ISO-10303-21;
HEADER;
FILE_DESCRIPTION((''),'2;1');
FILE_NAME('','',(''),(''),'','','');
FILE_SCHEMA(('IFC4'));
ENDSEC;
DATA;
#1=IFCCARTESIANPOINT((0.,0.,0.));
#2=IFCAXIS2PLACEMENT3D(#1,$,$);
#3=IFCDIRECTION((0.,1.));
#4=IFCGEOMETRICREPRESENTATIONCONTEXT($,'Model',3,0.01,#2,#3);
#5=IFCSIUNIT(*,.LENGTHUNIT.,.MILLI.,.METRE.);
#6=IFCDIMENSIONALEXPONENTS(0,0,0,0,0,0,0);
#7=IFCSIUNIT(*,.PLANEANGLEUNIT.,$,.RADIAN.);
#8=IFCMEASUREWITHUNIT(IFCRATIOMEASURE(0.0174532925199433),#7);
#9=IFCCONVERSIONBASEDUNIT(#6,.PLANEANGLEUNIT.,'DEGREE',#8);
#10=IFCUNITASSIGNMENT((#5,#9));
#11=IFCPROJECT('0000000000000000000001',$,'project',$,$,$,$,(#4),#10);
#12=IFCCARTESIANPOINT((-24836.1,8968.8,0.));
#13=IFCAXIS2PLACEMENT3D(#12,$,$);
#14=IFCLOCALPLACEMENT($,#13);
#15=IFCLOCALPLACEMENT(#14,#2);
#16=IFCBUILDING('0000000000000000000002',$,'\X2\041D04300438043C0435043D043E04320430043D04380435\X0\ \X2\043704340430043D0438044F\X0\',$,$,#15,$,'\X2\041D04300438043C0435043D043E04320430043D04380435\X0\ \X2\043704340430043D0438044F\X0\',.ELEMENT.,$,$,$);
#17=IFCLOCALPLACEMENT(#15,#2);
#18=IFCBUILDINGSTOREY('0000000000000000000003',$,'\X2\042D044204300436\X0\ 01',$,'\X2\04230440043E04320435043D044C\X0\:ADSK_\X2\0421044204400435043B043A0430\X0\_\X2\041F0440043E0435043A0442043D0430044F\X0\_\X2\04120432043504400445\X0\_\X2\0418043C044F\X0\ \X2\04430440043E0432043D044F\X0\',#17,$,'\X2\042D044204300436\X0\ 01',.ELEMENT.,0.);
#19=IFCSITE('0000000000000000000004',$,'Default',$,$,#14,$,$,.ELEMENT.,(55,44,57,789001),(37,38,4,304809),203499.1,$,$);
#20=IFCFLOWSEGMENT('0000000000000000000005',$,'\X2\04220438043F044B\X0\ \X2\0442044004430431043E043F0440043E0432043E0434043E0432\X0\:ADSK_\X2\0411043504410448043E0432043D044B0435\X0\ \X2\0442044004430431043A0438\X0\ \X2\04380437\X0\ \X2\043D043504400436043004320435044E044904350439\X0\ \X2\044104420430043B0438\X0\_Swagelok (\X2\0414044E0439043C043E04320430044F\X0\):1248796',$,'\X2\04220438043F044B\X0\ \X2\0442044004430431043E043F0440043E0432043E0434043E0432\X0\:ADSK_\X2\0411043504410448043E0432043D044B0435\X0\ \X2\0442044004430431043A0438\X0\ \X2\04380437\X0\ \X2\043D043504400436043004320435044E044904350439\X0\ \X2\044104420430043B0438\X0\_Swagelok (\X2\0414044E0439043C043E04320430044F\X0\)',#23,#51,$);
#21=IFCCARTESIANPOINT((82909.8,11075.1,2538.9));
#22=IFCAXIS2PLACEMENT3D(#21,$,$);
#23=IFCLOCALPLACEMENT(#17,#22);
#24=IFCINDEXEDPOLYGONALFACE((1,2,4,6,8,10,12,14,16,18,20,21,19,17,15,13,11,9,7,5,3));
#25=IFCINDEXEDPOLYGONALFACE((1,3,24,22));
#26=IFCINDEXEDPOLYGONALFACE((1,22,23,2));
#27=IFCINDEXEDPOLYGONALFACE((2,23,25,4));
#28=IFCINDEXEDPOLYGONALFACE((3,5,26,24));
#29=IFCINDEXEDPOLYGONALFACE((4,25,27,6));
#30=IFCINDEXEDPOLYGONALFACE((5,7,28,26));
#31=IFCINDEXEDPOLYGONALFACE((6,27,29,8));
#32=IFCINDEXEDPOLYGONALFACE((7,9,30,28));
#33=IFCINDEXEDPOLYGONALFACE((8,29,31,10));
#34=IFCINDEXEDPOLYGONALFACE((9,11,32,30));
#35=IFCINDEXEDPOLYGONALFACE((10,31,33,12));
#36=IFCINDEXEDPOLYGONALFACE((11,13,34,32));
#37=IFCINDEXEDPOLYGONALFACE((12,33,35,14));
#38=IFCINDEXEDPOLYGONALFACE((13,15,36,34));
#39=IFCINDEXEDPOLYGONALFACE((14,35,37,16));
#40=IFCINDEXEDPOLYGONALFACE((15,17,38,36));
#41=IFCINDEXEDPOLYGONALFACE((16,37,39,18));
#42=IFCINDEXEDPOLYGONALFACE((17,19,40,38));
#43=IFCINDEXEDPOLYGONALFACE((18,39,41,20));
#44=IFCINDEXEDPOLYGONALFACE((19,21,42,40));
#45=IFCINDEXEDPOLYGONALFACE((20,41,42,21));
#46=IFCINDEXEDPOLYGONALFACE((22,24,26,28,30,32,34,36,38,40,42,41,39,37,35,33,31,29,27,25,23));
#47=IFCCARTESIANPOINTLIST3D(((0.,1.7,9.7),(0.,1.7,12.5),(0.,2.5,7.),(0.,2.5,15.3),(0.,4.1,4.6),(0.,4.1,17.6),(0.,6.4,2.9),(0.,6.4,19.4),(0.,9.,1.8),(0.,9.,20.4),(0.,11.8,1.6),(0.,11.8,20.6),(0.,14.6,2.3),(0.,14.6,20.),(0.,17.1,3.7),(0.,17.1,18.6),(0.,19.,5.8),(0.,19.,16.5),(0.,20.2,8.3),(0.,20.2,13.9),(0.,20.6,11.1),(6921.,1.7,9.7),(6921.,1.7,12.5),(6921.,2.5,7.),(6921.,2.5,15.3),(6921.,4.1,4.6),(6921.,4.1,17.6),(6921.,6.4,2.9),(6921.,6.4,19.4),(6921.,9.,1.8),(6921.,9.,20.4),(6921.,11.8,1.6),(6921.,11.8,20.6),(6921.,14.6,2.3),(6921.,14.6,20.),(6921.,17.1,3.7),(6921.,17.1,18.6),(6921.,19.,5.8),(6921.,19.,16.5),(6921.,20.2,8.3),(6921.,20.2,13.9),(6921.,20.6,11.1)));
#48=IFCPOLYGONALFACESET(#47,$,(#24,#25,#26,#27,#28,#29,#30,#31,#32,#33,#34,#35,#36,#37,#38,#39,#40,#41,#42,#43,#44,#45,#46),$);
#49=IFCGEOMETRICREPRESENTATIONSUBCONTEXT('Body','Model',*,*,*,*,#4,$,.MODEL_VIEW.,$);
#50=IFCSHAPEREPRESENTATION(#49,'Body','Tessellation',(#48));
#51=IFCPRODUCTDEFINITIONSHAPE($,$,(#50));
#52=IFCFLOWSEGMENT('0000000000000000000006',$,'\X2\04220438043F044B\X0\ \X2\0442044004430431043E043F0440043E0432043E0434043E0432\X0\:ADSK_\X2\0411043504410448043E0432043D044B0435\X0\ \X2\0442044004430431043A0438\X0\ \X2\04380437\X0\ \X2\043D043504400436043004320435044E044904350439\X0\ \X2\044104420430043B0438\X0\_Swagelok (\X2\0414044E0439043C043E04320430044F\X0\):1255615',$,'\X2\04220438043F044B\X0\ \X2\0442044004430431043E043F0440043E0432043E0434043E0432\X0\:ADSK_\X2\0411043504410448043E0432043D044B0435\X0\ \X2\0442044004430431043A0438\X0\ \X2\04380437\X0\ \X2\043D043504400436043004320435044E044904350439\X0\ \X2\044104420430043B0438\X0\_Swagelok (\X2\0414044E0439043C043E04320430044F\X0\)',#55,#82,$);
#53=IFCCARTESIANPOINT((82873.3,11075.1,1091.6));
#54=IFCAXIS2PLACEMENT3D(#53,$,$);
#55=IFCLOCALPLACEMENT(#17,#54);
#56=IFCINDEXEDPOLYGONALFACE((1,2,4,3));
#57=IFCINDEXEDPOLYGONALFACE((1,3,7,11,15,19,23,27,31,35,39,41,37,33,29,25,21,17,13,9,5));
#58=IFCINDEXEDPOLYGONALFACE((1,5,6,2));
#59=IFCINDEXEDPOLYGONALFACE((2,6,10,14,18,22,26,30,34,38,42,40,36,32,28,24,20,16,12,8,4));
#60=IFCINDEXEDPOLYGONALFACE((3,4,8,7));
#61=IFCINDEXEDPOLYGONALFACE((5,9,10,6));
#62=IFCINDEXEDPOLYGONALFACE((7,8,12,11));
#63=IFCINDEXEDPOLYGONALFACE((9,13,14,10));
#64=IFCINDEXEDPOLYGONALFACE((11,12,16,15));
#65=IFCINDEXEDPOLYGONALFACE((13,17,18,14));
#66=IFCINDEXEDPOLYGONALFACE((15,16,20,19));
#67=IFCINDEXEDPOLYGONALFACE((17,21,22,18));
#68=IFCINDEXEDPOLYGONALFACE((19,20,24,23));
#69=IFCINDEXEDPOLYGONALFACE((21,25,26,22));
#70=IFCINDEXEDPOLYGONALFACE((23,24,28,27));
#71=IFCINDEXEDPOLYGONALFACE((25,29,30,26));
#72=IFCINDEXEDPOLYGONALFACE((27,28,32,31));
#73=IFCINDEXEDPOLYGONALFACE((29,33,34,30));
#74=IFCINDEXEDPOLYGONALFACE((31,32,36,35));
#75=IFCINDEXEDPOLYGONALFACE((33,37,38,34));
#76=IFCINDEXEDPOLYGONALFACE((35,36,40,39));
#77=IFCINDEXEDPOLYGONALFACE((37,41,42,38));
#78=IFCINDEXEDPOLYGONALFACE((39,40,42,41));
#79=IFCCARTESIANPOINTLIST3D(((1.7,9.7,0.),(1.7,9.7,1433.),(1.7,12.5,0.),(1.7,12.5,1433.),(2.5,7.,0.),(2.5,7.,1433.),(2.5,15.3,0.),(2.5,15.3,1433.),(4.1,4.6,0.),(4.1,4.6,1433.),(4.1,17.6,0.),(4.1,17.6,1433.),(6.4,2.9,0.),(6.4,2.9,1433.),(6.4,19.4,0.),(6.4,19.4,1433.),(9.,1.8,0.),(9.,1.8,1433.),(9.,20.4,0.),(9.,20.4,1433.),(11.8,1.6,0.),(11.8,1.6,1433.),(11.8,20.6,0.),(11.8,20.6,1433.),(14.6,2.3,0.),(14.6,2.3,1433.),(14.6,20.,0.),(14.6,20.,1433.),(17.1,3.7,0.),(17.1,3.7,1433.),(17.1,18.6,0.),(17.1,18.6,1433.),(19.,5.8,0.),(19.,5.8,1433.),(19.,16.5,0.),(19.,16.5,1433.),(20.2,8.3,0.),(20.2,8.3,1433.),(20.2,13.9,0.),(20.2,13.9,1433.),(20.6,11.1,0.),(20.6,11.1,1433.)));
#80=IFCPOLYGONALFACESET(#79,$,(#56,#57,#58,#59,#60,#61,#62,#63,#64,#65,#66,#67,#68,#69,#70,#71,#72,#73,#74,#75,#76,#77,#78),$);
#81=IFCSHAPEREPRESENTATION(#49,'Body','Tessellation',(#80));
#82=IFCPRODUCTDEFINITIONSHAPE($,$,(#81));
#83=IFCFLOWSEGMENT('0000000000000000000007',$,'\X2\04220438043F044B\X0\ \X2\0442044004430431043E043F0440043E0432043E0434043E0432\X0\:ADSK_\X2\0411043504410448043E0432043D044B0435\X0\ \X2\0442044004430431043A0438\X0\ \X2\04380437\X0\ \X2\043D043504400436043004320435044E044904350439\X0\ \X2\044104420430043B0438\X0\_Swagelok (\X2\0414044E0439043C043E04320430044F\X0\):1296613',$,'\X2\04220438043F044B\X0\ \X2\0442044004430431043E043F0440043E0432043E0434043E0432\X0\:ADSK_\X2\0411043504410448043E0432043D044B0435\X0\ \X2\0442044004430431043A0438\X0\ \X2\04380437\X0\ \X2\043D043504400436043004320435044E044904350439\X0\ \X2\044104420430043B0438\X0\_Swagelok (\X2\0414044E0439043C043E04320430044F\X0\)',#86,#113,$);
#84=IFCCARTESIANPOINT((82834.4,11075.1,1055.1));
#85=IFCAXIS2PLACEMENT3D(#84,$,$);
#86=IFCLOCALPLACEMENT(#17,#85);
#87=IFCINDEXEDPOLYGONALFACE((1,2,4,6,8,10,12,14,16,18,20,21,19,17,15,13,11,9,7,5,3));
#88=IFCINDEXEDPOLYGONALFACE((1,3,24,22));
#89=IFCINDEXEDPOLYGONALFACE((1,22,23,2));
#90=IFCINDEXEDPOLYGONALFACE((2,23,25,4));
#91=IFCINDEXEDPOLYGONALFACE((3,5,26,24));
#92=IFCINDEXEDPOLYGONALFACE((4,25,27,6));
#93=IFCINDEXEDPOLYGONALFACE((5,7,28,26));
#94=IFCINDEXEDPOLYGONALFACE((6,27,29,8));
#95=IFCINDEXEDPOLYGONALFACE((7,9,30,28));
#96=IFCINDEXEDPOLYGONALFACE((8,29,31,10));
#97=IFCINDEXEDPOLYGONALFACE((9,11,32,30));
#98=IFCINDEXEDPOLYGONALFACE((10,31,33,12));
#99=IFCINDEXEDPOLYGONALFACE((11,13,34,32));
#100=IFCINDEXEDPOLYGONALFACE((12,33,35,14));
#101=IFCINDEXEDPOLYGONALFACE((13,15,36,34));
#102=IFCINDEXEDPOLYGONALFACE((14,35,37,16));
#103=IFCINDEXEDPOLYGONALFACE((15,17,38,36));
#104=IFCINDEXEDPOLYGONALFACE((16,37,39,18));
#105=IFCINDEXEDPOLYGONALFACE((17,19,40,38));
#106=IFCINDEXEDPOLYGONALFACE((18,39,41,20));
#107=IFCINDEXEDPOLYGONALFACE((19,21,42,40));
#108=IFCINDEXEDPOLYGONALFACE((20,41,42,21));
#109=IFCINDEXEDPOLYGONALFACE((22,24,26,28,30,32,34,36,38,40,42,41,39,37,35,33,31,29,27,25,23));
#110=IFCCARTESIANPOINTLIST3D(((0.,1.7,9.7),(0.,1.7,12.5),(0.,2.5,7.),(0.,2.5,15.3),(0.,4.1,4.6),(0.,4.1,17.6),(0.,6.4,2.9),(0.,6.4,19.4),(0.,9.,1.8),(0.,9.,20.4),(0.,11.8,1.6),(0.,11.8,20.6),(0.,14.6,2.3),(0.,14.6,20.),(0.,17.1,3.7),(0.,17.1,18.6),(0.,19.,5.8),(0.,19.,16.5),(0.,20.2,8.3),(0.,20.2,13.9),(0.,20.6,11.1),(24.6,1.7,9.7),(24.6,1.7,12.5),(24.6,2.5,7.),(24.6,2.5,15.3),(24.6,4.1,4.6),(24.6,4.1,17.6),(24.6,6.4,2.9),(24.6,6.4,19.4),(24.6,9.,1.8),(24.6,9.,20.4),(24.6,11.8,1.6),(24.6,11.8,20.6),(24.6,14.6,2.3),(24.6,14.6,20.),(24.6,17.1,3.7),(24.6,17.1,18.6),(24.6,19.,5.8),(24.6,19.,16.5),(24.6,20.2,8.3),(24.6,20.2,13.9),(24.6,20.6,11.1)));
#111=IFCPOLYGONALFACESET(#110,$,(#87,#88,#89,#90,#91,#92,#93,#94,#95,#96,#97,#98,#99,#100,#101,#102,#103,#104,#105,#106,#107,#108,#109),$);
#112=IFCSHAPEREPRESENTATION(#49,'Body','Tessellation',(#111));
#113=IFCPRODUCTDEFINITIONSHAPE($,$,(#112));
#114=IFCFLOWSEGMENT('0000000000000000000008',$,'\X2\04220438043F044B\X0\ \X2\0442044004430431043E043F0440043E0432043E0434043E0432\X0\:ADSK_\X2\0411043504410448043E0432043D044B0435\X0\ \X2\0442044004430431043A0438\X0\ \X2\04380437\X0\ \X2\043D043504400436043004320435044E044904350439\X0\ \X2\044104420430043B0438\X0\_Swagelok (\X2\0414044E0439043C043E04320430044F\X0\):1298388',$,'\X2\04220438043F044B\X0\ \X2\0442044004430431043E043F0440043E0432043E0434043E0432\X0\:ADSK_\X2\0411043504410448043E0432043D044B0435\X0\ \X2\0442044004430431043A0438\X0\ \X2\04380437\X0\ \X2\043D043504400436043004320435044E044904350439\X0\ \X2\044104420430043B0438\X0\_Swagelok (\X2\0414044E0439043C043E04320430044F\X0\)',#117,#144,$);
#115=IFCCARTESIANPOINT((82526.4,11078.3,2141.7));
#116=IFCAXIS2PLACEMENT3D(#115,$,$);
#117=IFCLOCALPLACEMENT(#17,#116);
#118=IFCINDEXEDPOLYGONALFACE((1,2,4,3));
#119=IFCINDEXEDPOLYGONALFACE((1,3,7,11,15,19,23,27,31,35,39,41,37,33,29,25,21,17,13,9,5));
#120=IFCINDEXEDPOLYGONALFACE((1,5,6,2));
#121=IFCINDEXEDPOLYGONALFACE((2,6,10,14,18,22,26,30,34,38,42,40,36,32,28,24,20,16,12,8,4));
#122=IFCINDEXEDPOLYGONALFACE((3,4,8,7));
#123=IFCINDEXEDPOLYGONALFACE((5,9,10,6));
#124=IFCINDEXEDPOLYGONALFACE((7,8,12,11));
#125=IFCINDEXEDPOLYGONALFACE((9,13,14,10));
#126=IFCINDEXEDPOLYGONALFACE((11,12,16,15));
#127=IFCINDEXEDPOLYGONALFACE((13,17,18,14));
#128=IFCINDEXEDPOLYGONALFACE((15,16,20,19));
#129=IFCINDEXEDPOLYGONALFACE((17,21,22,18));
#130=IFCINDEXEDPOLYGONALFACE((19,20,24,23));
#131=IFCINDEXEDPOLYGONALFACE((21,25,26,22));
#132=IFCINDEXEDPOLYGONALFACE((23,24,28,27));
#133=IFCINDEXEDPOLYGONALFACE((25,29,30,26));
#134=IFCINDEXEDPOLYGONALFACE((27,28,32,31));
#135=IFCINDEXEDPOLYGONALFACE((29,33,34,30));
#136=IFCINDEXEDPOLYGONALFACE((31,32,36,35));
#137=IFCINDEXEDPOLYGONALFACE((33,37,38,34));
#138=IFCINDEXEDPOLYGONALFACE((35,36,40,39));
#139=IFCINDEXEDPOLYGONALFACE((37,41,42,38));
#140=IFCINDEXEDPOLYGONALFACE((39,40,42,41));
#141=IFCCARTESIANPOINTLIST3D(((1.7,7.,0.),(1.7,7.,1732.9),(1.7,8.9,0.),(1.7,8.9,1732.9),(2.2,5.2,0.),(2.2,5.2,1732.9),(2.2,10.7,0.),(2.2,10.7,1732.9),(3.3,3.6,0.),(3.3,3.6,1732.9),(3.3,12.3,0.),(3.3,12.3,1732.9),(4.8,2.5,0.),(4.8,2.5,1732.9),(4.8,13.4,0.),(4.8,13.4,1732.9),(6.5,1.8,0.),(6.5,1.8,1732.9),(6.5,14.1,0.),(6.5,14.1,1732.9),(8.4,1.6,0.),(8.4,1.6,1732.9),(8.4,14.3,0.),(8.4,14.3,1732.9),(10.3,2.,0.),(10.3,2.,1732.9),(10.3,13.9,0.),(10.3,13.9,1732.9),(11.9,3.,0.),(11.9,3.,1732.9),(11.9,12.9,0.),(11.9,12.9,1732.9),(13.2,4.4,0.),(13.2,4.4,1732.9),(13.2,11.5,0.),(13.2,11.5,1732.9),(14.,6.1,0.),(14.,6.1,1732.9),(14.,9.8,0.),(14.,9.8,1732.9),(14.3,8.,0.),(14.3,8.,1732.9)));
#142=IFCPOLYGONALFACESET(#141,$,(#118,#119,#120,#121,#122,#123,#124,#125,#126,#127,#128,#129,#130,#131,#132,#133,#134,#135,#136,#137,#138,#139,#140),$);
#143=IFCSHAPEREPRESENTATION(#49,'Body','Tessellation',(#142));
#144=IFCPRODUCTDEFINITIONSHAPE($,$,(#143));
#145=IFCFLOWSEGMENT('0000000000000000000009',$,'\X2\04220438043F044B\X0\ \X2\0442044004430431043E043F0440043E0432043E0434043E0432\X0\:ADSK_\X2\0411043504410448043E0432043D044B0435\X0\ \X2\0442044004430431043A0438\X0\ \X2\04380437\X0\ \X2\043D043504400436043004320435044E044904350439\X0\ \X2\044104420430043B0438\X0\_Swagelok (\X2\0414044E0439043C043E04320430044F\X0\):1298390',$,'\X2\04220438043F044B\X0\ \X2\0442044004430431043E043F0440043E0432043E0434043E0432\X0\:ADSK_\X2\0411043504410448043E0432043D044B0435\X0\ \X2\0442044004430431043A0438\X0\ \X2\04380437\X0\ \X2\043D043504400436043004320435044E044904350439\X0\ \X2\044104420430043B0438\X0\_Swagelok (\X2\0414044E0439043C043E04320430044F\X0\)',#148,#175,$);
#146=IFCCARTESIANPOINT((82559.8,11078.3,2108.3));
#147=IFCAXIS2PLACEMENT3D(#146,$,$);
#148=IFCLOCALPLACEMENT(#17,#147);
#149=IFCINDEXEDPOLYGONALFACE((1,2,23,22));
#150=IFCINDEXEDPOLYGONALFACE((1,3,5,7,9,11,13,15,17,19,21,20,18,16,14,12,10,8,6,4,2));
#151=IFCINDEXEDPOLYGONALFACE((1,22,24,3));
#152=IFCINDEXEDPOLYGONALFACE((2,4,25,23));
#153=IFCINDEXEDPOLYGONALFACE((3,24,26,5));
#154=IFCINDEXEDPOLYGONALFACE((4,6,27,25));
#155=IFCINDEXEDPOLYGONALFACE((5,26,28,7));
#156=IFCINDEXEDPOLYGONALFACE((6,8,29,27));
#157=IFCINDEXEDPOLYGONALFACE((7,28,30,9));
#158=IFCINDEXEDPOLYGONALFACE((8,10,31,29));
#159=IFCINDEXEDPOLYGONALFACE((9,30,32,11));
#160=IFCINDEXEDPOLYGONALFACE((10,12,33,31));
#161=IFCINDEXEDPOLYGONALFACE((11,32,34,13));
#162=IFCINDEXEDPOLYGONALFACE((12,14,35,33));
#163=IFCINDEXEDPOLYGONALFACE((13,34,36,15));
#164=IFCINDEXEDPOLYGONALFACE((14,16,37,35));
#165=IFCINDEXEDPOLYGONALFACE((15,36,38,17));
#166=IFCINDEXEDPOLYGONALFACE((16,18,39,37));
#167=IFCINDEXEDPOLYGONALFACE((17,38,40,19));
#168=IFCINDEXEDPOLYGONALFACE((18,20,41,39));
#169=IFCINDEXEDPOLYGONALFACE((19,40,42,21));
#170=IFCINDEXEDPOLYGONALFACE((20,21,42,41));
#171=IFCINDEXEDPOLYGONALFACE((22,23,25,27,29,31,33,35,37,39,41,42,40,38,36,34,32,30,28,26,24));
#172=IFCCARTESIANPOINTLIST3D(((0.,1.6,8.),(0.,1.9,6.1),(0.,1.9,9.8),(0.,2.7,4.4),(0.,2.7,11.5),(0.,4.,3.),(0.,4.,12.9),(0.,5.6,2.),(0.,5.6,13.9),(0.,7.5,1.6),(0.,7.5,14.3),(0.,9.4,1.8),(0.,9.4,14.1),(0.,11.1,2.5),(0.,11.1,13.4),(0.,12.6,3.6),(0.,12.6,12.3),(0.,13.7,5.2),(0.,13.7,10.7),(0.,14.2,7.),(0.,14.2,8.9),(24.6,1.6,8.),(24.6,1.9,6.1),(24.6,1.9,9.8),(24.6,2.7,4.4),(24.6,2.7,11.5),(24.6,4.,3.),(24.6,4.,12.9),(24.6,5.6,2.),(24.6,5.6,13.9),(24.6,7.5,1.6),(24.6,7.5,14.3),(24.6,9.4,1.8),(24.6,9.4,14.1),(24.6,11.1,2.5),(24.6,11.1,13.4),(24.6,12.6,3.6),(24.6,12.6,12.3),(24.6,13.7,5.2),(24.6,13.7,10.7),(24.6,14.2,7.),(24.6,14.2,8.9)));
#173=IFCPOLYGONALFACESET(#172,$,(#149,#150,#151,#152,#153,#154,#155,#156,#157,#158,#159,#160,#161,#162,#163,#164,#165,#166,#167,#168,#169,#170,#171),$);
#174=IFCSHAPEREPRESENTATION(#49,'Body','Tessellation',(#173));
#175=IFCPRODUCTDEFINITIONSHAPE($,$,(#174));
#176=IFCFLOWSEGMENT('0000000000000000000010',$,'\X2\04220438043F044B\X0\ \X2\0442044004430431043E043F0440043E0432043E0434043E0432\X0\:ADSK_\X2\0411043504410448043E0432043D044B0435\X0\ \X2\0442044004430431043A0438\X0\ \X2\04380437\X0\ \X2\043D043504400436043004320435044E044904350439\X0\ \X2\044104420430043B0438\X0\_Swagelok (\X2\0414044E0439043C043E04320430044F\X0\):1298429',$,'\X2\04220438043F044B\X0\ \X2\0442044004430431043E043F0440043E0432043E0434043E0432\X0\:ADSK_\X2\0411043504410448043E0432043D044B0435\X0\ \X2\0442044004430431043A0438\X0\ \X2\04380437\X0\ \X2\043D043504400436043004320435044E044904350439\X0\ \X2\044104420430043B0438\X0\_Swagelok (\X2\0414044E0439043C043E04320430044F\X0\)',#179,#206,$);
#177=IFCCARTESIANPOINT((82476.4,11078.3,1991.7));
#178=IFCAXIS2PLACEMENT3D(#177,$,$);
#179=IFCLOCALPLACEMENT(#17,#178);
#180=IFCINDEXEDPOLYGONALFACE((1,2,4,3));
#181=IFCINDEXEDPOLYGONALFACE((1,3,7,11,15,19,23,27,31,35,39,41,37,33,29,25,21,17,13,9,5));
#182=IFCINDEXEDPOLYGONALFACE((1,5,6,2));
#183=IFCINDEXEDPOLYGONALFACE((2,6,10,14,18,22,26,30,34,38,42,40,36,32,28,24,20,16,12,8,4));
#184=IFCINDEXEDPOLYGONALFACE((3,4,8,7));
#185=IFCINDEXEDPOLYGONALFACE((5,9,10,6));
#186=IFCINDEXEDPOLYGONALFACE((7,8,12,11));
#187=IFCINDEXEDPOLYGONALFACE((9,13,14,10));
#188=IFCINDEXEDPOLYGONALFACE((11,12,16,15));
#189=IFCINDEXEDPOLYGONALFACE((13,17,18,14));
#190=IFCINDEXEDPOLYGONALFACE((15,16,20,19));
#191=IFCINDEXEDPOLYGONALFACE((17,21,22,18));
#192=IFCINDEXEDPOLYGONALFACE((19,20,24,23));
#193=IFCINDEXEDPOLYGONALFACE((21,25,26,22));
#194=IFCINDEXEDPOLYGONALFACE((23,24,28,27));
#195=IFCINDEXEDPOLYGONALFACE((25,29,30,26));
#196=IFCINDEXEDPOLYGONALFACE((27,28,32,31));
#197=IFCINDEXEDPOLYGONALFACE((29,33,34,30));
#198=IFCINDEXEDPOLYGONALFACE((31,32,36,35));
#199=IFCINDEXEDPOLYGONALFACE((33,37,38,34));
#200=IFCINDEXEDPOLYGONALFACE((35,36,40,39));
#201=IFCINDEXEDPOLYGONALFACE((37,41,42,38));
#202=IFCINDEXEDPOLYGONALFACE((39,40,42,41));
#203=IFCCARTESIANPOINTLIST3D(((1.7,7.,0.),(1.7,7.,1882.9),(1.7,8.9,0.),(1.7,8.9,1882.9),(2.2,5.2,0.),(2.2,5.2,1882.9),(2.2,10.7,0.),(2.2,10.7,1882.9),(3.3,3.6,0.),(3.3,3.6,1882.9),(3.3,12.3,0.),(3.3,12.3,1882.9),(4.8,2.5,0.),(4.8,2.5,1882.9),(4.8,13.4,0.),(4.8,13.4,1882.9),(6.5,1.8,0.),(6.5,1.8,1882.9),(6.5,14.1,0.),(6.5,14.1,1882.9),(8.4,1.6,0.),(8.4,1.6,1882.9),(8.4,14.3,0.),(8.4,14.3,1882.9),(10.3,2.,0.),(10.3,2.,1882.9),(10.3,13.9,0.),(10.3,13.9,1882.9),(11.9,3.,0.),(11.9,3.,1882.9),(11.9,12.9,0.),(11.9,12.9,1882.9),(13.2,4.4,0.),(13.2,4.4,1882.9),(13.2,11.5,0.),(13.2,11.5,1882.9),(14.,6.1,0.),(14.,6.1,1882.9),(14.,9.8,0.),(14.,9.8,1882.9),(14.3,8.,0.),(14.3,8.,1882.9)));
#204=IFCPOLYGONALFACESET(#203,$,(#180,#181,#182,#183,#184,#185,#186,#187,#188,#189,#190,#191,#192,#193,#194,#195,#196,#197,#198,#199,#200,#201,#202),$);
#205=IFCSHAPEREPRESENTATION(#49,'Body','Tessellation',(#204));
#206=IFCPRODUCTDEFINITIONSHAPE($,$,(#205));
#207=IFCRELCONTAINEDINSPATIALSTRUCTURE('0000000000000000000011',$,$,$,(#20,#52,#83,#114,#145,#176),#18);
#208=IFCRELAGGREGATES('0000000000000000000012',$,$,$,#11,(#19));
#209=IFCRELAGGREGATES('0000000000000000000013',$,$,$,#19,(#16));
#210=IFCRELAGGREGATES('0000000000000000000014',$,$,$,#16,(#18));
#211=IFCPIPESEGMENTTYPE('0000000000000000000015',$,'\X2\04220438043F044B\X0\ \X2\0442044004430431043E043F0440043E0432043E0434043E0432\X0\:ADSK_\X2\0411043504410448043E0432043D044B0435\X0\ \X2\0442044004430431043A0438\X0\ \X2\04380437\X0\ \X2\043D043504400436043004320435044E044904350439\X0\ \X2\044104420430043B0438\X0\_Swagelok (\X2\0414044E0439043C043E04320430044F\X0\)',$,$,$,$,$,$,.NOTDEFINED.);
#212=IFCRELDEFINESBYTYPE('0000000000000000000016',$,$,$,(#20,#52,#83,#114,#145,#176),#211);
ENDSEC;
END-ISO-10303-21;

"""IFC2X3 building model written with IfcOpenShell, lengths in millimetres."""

from ifc_helpers import new_model, entity, si_unit, converted_unit, direction, frame, origin, origin_2d_with_axis, place, context, subcontext, project, spatial, circle, extrude, type_object, element, save


model = new_model("IFC2X3")

# Units and contexts
model_context = context("Model", 3, precision=0.01, world=origin(), true_north=direction((0.0, 1.0)))
body_context = subcontext(model_context, "Body", "Model", "MODEL_VIEW")
ifc_project = project(units=[si_unit("LENGTHUNIT", "METRE", prefix="MILLI"), converted_unit("PLANEANGLEUNIT", "DEGREE", entity("IfcRatioMeasure", 0.0174532925199433), si_unit("PLANEANGLEUNIT", "RADIAN"), dimensions=[0, 0, 0, 0, 0, 0, 0])], contexts=[model_context])

# Site, building, storey
site_placement = place(None, frame((-24836.1, 8968.8, 0.0)))
site = spatial("IfcSite", under=ifc_project, at=site_placement, Name="Default", CompositionType="ELEMENT", RefLatitude=(55, 44, 57, 789001), RefLongitude=(37, 38, 4, 304809), RefElevation=203499.1)
building_placement = place(site_placement, origin())
building = spatial("IfcBuilding", under=site, at=building_placement, Name="Наименование здания", LongName="Наименование здания", CompositionType="ELEMENT")
storey_placement = place(building_placement, origin())
storey = spatial("IfcBuildingStorey", under=building, at=storey_placement, Name="Этаж 01", ObjectType="Уровень:ADSK_Стрелка_Проектная_Вверх_Имя уровня", LongName="Этаж 01", CompositionType="ELEMENT", Elevation=0.0)

# Flow segments
pipe_segment_type = type_object("IfcPipeSegmentType", Name="Типы трубопроводов:ADSK_Бесшовные трубки из нержавеющей стали_Swagelok (Дюймовая)", PredefinedType="NOTDEFINED")
flow_segment_1_placement = place(storey_placement, frame((82909.8, 11075.1, 2538.9)))
element("IfcFlowSegment", 1, at=flow_segment_1_placement, inside=storey, type_object=pipe_segment_type, Name="Типы трубопроводов:ADSK_Бесшовные трубки из нержавеющей стали_Swagelok (Дюймовая):1248796", ObjectType="Типы трубопроводов:ADSK_Бесшовные трубки из нержавеющей стали_Swagelok (Дюймовая)", context=body_context, shape_type="SweptSolid", body=[
    extrude(circle(Radius=9.5, at=origin_2d_with_axis()), frame((0.0, 11.1, 11.1), z_axis=(1.0, 0.0, 0.0), x_axis=(0.0, 1.0, 0.0)), (0.0, 0.0, 1.0), 6921.0),
])
flow_segment_2_placement = place(storey_placement, frame((82873.3, 11075.1, 1091.6)))
element("IfcFlowSegment", 2, at=flow_segment_2_placement, inside=storey, type_object=pipe_segment_type, Name="Типы трубопроводов:ADSK_Бесшовные трубки из нержавеющей стали_Swagelok (Дюймовая):1255615", ObjectType="Типы трубопроводов:ADSK_Бесшовные трубки из нержавеющей стали_Swagelok (Дюймовая)", context=body_context, shape_type="SweptSolid", body=[
    extrude(circle(Radius=9.5, at=origin_2d_with_axis()), frame((11.1, 11.1, 0.0)), (0.0, 0.0, 1.0), 1433.0),
])
flow_segment_3_placement = place(storey_placement, frame((82834.4, 11075.1, 1055.1)))
element("IfcFlowSegment", 3, at=flow_segment_3_placement, inside=storey, type_object=pipe_segment_type, Name="Типы трубопроводов:ADSK_Бесшовные трубки из нержавеющей стали_Swagelok (Дюймовая):1296613", ObjectType="Типы трубопроводов:ADSK_Бесшовные трубки из нержавеющей стали_Swagelok (Дюймовая)", context=body_context, shape_type="SweptSolid", body=[
    extrude(circle(Radius=9.5, at=origin_2d_with_axis()), frame((0.0, 11.1, 11.1), z_axis=(1.0, 0.0, 0.0), x_axis=(0.0, 1.0, 0.0)), (0.0, 0.0, 1.0), 24.6),
])
flow_segment_4_placement = place(storey_placement, frame((82526.4, 11078.3, 2141.7)))
element("IfcFlowSegment", 4, at=flow_segment_4_placement, inside=storey, type_object=pipe_segment_type, Name="Типы трубопроводов:ADSK_Бесшовные трубки из нержавеющей стали_Swagelok (Дюймовая):1298388", ObjectType="Типы трубопроводов:ADSK_Бесшовные трубки из нержавеющей стали_Swagelok (Дюймовая)", context=body_context, shape_type="SweptSolid", body=[
    extrude(circle(Radius=6.3, at=origin_2d_with_axis()), frame((8.0, 8.0, 0.0)), (0.0, 0.0, 1.0), 1732.9),
])
flow_segment_5_placement = place(storey_placement, frame((82559.8, 11078.3, 2108.3)))
element("IfcFlowSegment", 5, at=flow_segment_5_placement, inside=storey, type_object=pipe_segment_type, Name="Типы трубопроводов:ADSK_Бесшовные трубки из нержавеющей стали_Swagelok (Дюймовая):1298390", ObjectType="Типы трубопроводов:ADSK_Бесшовные трубки из нержавеющей стали_Swagelok (Дюймовая)", context=body_context, shape_type="SweptSolid", body=[
    extrude(circle(Radius=6.3, at=origin_2d_with_axis()), frame((0.0, 8.0, 8.0), z_axis=(1.0, 0.0, 0.0), x_axis=(0.0, -1.0, 0.0)), (0.0, 0.0, 1.0), 24.6),
])
flow_segment_6_placement = place(storey_placement, frame((82476.4, 11078.3, 1991.7)))
element("IfcFlowSegment", 6, at=flow_segment_6_placement, inside=storey, type_object=pipe_segment_type, Name="Типы трубопроводов:ADSK_Бесшовные трубки из нержавеющей стали_Swagelok (Дюймовая):1298429", ObjectType="Типы трубопроводов:ADSK_Бесшовные трубки из нержавеющей стали_Swagelok (Дюймовая)", context=body_context, shape_type="SweptSolid", body=[
    extrude(circle(Radius=6.3, at=origin_2d_with_axis()), frame((8.0, 8.0, 0.0)), (0.0, 0.0, 1.0), 1882.9),
])

save(model, "model.ifc")
